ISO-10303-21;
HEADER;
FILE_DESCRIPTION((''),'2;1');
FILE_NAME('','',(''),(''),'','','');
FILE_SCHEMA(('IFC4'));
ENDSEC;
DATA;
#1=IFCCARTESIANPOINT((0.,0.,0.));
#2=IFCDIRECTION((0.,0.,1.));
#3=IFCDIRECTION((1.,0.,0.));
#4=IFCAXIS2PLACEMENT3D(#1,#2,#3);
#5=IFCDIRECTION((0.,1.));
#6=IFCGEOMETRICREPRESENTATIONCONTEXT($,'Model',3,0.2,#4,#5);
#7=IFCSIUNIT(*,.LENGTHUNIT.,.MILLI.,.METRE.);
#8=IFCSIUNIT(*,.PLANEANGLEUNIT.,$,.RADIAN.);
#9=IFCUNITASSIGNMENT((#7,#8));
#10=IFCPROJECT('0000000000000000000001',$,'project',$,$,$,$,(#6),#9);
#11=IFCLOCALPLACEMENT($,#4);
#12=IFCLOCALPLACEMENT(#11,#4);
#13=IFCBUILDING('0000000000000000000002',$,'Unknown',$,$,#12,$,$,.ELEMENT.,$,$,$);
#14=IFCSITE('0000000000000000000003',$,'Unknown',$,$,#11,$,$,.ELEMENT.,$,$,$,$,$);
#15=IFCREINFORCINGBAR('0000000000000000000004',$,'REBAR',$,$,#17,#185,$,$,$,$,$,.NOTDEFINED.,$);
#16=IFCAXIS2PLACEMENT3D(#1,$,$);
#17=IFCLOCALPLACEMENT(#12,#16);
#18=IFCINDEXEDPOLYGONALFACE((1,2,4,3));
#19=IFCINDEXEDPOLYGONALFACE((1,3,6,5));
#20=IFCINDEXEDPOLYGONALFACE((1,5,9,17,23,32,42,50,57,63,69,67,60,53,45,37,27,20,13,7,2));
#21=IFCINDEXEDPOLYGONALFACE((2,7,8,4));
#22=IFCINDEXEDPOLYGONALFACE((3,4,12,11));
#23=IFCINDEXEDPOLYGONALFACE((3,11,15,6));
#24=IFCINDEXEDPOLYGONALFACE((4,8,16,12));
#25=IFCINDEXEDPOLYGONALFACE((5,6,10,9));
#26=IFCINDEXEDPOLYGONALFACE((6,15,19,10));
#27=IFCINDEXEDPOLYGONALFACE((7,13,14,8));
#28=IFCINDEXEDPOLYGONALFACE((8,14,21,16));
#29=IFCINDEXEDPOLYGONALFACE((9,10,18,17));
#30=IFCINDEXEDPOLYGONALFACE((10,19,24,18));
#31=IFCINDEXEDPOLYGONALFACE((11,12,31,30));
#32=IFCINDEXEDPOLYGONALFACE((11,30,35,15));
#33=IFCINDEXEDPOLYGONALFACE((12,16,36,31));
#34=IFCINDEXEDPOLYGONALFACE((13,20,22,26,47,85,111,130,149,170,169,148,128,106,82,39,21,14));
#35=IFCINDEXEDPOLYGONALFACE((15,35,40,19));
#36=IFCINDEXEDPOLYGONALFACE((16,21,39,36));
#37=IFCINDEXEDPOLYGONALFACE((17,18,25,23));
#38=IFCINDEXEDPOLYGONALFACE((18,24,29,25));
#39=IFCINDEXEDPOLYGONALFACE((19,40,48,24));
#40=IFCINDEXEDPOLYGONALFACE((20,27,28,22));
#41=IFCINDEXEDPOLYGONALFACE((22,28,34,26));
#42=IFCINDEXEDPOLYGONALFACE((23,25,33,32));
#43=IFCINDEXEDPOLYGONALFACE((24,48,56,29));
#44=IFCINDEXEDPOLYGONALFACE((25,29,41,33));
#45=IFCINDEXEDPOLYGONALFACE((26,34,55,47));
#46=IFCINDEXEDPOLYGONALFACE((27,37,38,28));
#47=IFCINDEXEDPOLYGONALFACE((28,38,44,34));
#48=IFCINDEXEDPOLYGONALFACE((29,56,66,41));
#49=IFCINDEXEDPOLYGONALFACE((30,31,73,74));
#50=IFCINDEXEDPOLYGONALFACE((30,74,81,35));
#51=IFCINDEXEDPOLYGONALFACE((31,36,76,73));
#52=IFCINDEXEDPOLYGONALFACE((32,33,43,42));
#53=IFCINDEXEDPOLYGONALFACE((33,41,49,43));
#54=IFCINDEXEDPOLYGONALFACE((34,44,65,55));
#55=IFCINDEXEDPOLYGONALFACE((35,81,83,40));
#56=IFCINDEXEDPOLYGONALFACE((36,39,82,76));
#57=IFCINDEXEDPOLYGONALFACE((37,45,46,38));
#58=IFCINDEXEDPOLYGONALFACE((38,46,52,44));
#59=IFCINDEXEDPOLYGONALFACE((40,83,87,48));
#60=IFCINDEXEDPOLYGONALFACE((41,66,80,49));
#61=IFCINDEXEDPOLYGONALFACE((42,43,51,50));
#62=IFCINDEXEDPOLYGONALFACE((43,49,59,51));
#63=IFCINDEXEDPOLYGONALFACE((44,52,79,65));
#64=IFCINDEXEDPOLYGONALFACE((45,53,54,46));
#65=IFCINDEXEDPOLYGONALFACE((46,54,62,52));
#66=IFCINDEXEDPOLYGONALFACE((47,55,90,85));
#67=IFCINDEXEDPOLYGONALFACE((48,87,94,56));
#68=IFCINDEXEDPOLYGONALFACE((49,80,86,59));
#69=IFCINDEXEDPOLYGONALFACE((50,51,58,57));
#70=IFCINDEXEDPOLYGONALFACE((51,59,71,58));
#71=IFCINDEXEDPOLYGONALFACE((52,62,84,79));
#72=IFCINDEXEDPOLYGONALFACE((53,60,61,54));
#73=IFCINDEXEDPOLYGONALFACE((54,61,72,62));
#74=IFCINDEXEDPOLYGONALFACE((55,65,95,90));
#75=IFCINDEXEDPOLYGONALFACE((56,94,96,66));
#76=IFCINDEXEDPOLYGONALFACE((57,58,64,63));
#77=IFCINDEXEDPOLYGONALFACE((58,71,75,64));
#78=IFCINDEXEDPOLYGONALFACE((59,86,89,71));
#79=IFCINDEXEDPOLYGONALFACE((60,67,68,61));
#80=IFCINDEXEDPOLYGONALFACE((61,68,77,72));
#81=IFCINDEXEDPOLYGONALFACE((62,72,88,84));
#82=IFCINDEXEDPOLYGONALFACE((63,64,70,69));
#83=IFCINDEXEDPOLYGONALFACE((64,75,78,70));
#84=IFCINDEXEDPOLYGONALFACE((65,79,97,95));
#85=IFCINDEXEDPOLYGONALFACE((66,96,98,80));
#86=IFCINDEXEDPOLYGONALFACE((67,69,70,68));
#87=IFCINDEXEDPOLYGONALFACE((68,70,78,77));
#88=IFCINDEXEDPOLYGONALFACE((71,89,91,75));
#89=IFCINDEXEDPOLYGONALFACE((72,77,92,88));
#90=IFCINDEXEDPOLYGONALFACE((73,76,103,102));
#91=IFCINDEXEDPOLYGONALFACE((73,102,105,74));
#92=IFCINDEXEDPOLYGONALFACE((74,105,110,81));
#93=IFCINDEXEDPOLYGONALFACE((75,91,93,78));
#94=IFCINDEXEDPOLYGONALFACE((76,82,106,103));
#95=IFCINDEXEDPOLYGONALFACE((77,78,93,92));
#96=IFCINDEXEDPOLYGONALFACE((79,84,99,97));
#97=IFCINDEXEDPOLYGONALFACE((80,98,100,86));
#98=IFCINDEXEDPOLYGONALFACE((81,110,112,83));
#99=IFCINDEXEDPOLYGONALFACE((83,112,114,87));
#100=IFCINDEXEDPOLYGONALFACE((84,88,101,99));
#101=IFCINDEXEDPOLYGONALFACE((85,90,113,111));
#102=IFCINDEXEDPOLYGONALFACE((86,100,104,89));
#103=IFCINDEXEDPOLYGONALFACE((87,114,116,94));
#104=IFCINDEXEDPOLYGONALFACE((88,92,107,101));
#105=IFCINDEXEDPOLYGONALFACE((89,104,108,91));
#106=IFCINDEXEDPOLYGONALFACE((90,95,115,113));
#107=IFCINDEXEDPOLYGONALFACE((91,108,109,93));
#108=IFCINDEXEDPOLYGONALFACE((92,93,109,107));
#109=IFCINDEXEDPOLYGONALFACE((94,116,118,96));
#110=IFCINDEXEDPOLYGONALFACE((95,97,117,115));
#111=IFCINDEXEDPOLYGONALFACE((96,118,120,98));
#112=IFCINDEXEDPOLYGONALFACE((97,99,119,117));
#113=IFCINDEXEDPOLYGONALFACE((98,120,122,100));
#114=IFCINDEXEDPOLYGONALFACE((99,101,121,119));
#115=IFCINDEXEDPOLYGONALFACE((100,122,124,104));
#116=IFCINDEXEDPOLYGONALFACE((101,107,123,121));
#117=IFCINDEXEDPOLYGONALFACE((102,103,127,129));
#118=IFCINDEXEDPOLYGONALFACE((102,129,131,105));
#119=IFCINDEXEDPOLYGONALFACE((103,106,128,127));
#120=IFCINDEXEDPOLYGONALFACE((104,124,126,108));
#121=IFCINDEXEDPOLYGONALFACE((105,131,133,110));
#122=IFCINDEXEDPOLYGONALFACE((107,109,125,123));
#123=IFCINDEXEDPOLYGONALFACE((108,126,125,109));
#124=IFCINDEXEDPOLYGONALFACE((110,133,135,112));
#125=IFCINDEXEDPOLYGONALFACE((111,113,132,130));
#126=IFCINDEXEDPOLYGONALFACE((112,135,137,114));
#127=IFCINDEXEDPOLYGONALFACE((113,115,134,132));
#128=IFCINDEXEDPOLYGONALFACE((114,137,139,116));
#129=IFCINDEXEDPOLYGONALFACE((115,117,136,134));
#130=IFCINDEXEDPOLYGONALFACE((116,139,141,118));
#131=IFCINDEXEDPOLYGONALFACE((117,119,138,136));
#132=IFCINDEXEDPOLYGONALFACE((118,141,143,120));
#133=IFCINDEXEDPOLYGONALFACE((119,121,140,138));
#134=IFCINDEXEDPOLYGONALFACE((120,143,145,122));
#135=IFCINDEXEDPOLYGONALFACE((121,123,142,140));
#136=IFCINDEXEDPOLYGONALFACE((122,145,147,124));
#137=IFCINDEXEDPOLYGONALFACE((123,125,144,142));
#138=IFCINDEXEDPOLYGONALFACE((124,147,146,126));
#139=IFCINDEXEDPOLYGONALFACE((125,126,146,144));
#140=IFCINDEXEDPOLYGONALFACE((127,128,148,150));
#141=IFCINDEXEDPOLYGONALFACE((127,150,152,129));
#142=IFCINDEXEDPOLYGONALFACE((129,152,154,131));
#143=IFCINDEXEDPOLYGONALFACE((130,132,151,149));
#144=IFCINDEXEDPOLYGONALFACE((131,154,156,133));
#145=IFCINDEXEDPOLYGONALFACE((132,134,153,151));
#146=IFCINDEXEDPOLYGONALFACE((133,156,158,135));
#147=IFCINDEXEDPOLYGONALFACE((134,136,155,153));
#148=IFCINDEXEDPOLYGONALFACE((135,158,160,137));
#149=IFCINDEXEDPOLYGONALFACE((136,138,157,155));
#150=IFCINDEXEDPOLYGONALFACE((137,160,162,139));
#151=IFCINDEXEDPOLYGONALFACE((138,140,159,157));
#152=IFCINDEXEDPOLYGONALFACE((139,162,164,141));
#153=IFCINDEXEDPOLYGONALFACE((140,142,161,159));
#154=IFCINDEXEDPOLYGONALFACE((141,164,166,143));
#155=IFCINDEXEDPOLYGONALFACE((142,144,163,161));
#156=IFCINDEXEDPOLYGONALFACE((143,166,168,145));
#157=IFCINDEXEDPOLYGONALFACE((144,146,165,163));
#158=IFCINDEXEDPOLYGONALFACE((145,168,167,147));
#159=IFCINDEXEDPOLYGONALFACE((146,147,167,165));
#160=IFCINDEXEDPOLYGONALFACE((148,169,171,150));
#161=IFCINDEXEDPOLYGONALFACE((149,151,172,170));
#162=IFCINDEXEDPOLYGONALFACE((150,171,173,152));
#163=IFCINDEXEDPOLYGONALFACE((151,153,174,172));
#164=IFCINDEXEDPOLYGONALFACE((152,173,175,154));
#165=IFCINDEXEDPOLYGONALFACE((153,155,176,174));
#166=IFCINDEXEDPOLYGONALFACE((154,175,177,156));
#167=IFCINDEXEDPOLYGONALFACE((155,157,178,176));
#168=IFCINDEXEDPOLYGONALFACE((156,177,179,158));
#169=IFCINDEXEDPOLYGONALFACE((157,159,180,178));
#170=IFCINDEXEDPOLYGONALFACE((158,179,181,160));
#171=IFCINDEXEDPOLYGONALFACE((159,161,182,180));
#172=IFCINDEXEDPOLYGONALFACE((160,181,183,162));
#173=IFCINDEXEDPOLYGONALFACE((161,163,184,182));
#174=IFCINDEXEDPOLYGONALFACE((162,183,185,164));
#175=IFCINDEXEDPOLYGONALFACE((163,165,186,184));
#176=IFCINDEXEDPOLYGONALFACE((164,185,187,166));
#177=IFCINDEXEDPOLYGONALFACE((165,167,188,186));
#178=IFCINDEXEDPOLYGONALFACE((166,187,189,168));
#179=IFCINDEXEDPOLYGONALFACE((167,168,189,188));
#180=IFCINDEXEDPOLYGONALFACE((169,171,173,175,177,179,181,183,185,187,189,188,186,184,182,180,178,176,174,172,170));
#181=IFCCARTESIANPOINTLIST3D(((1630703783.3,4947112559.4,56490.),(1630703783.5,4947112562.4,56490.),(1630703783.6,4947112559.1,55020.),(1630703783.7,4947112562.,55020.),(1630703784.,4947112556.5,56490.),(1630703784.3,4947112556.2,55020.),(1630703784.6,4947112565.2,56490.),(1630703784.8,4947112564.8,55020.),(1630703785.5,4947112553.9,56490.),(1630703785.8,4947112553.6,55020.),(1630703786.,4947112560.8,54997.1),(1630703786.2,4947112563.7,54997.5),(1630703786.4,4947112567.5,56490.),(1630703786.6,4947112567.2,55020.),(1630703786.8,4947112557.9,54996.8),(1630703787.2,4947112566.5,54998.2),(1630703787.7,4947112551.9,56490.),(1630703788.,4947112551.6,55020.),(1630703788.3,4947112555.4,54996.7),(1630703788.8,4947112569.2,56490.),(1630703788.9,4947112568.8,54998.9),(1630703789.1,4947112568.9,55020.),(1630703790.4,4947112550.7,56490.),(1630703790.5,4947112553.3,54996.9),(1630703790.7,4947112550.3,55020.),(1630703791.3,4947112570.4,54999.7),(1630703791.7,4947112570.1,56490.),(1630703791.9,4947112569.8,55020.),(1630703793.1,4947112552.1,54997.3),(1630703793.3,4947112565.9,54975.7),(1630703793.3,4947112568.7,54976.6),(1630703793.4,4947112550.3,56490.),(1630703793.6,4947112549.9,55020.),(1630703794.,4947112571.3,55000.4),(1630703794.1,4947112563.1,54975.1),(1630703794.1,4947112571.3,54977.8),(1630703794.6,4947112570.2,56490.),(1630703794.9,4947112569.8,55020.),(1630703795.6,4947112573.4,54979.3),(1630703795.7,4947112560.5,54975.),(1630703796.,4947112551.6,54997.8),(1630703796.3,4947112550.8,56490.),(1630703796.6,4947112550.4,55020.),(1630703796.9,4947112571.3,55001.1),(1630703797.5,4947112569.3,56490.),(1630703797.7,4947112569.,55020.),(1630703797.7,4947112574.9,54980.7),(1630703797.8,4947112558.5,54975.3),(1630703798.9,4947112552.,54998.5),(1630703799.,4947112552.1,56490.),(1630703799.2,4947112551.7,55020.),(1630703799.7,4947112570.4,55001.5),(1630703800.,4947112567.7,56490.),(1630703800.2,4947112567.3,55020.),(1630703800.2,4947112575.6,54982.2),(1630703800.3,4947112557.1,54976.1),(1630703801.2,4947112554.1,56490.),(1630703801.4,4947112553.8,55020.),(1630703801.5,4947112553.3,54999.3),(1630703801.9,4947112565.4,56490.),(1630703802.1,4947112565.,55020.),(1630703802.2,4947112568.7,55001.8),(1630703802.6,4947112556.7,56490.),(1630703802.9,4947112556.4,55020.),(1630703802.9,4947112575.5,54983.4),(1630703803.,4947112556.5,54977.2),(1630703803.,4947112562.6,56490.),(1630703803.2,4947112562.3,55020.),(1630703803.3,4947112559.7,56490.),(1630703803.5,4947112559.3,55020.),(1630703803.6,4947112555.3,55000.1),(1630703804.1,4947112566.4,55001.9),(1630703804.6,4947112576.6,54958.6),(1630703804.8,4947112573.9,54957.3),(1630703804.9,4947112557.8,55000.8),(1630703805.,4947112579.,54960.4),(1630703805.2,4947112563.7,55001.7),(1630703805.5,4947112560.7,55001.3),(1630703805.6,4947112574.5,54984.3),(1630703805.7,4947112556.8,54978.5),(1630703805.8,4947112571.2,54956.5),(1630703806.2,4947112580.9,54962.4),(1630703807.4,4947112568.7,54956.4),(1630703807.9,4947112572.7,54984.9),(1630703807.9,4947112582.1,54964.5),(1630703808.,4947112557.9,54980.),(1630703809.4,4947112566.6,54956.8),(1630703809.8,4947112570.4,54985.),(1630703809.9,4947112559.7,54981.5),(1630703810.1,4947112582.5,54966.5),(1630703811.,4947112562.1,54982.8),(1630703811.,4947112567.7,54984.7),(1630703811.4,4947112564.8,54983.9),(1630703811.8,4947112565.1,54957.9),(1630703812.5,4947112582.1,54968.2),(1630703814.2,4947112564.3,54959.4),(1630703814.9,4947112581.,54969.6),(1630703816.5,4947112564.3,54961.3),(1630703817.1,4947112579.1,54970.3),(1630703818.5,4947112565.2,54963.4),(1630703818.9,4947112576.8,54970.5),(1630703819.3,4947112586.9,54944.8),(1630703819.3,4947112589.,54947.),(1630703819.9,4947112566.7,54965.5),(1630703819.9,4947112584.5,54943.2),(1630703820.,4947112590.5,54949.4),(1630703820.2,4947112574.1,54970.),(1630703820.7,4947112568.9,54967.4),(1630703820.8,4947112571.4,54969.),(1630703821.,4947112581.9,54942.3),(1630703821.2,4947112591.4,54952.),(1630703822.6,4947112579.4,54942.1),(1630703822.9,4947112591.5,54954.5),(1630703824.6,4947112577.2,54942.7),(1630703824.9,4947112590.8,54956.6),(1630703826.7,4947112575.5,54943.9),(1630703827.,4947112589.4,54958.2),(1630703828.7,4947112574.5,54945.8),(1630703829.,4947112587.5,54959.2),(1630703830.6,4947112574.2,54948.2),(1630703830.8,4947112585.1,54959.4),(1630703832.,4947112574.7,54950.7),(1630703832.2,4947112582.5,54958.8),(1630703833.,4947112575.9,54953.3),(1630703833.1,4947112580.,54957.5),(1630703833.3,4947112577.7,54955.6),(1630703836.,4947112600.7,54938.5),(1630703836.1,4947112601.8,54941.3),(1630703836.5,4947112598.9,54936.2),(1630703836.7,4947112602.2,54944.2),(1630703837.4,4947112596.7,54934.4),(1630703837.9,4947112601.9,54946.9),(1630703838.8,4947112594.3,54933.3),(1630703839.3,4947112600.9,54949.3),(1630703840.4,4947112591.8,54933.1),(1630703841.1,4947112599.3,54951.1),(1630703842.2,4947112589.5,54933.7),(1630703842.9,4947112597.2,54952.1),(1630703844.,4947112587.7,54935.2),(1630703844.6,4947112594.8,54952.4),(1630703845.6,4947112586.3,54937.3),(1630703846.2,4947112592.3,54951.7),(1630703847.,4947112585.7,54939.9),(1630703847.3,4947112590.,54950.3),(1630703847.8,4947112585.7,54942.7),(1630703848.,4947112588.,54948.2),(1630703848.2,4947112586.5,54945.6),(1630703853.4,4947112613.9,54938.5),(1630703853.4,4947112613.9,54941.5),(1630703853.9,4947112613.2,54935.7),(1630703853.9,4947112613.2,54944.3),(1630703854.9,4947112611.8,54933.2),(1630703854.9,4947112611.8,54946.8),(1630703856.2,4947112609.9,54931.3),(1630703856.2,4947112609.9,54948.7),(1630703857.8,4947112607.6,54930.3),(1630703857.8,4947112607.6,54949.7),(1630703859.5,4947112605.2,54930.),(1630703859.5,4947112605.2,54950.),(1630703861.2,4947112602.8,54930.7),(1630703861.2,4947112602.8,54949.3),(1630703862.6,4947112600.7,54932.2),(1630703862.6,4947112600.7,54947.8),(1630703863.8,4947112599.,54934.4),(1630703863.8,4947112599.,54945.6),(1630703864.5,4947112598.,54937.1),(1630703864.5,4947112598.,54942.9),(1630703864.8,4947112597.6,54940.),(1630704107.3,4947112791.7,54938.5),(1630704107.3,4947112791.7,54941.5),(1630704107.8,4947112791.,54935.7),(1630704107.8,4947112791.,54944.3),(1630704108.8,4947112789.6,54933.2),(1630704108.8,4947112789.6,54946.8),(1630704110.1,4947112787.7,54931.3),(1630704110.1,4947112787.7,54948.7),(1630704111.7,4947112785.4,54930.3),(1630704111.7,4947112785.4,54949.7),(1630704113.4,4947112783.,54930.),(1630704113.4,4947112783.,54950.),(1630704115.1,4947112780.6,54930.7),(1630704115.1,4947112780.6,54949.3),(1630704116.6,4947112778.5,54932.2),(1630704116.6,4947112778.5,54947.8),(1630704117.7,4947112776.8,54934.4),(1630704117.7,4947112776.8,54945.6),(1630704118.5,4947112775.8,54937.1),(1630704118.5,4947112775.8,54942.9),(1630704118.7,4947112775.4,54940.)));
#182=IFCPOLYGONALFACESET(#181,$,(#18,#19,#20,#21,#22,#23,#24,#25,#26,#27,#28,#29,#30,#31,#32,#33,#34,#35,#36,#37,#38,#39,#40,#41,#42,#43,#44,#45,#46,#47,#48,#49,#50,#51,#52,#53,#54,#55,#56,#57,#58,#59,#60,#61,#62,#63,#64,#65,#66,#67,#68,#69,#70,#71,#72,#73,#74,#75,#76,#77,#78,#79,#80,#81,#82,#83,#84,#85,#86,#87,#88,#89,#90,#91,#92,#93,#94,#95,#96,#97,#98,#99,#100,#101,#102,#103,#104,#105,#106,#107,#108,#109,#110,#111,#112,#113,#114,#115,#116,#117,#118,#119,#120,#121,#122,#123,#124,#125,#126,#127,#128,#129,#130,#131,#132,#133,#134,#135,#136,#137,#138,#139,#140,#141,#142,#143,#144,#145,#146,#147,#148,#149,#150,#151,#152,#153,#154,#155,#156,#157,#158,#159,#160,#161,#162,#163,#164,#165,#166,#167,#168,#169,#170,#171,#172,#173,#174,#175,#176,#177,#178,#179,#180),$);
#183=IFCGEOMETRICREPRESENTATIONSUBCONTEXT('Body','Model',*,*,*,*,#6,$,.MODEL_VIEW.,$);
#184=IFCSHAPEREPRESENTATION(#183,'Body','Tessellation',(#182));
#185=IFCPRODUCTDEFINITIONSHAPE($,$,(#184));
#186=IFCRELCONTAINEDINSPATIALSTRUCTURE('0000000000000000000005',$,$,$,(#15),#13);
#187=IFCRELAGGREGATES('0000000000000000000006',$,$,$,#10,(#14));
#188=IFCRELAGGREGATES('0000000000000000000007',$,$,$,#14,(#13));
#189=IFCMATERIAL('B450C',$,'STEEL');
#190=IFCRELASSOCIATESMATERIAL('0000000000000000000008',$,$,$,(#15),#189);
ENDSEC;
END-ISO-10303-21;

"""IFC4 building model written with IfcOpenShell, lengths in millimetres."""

from ifc_helpers import new_model, entity, si_unit, direction, frame, origin_with_axes, place, context, subcontext, project, spatial, material, element, save


model = new_model("IFC4")

# Units and contexts
model_context = context("Model", 3, precision=0.2, world=origin_with_axes(), true_north=direction((0.0, 1.0)))
body_context = subcontext(model_context, "Body", "Model", "MODEL_VIEW")
ifc_project = project(units=[si_unit("LENGTHUNIT", "METRE", prefix="MILLI"), si_unit("PLANEANGLEUNIT", "RADIAN")], contexts=[model_context])

# Site, building
site_placement = place(None, origin_with_axes())
site = spatial("IfcSite", under=ifc_project, at=site_placement, Name="Unknown", CompositionType="ELEMENT")
building_placement = place(site_placement, origin_with_axes())
building = spatial("IfcBuilding", under=site, at=building_placement, Name="Unknown", CompositionType="ELEMENT")

# Reinforcing bar
ifc_material = material(Name="B450C", Category="STEEL")
reinforcing_bar_1_placement = place(building_placement, frame((1630703723.9, 4947112572.2, 54890.0), z_axis=(0.573819, -0.818982, 0.0), x_axis=(0.0, 0.0, 1.0)))
element("IfcReinforcingBar", 1, at=reinforcing_bar_1_placement, inside=building, material=ifc_material, Name="REBAR", PredefinedType="NOTDEFINED", context=body_context, shape_type="AdvancedSweptSolid", body=[
    entity("IfcSweptDiskSolid", entity("IfcIndexedPolyCurve", entity("IfcCartesianPointList3D", [[50.0, -440.0, 50.1], [50.0, -130.0, 50.0], [73.4, -73.4, 50.0], [130.0, -50.0, 50.0], [1600.0, -50.0, 49.6]]), [entity("IfcLineIndex", [1, 2]), entity("IfcArcIndex", [2, 3, 4]), entity("IfcLineIndex", [4, 5])]), 10.0),
])

save(model, "model.ifc")
